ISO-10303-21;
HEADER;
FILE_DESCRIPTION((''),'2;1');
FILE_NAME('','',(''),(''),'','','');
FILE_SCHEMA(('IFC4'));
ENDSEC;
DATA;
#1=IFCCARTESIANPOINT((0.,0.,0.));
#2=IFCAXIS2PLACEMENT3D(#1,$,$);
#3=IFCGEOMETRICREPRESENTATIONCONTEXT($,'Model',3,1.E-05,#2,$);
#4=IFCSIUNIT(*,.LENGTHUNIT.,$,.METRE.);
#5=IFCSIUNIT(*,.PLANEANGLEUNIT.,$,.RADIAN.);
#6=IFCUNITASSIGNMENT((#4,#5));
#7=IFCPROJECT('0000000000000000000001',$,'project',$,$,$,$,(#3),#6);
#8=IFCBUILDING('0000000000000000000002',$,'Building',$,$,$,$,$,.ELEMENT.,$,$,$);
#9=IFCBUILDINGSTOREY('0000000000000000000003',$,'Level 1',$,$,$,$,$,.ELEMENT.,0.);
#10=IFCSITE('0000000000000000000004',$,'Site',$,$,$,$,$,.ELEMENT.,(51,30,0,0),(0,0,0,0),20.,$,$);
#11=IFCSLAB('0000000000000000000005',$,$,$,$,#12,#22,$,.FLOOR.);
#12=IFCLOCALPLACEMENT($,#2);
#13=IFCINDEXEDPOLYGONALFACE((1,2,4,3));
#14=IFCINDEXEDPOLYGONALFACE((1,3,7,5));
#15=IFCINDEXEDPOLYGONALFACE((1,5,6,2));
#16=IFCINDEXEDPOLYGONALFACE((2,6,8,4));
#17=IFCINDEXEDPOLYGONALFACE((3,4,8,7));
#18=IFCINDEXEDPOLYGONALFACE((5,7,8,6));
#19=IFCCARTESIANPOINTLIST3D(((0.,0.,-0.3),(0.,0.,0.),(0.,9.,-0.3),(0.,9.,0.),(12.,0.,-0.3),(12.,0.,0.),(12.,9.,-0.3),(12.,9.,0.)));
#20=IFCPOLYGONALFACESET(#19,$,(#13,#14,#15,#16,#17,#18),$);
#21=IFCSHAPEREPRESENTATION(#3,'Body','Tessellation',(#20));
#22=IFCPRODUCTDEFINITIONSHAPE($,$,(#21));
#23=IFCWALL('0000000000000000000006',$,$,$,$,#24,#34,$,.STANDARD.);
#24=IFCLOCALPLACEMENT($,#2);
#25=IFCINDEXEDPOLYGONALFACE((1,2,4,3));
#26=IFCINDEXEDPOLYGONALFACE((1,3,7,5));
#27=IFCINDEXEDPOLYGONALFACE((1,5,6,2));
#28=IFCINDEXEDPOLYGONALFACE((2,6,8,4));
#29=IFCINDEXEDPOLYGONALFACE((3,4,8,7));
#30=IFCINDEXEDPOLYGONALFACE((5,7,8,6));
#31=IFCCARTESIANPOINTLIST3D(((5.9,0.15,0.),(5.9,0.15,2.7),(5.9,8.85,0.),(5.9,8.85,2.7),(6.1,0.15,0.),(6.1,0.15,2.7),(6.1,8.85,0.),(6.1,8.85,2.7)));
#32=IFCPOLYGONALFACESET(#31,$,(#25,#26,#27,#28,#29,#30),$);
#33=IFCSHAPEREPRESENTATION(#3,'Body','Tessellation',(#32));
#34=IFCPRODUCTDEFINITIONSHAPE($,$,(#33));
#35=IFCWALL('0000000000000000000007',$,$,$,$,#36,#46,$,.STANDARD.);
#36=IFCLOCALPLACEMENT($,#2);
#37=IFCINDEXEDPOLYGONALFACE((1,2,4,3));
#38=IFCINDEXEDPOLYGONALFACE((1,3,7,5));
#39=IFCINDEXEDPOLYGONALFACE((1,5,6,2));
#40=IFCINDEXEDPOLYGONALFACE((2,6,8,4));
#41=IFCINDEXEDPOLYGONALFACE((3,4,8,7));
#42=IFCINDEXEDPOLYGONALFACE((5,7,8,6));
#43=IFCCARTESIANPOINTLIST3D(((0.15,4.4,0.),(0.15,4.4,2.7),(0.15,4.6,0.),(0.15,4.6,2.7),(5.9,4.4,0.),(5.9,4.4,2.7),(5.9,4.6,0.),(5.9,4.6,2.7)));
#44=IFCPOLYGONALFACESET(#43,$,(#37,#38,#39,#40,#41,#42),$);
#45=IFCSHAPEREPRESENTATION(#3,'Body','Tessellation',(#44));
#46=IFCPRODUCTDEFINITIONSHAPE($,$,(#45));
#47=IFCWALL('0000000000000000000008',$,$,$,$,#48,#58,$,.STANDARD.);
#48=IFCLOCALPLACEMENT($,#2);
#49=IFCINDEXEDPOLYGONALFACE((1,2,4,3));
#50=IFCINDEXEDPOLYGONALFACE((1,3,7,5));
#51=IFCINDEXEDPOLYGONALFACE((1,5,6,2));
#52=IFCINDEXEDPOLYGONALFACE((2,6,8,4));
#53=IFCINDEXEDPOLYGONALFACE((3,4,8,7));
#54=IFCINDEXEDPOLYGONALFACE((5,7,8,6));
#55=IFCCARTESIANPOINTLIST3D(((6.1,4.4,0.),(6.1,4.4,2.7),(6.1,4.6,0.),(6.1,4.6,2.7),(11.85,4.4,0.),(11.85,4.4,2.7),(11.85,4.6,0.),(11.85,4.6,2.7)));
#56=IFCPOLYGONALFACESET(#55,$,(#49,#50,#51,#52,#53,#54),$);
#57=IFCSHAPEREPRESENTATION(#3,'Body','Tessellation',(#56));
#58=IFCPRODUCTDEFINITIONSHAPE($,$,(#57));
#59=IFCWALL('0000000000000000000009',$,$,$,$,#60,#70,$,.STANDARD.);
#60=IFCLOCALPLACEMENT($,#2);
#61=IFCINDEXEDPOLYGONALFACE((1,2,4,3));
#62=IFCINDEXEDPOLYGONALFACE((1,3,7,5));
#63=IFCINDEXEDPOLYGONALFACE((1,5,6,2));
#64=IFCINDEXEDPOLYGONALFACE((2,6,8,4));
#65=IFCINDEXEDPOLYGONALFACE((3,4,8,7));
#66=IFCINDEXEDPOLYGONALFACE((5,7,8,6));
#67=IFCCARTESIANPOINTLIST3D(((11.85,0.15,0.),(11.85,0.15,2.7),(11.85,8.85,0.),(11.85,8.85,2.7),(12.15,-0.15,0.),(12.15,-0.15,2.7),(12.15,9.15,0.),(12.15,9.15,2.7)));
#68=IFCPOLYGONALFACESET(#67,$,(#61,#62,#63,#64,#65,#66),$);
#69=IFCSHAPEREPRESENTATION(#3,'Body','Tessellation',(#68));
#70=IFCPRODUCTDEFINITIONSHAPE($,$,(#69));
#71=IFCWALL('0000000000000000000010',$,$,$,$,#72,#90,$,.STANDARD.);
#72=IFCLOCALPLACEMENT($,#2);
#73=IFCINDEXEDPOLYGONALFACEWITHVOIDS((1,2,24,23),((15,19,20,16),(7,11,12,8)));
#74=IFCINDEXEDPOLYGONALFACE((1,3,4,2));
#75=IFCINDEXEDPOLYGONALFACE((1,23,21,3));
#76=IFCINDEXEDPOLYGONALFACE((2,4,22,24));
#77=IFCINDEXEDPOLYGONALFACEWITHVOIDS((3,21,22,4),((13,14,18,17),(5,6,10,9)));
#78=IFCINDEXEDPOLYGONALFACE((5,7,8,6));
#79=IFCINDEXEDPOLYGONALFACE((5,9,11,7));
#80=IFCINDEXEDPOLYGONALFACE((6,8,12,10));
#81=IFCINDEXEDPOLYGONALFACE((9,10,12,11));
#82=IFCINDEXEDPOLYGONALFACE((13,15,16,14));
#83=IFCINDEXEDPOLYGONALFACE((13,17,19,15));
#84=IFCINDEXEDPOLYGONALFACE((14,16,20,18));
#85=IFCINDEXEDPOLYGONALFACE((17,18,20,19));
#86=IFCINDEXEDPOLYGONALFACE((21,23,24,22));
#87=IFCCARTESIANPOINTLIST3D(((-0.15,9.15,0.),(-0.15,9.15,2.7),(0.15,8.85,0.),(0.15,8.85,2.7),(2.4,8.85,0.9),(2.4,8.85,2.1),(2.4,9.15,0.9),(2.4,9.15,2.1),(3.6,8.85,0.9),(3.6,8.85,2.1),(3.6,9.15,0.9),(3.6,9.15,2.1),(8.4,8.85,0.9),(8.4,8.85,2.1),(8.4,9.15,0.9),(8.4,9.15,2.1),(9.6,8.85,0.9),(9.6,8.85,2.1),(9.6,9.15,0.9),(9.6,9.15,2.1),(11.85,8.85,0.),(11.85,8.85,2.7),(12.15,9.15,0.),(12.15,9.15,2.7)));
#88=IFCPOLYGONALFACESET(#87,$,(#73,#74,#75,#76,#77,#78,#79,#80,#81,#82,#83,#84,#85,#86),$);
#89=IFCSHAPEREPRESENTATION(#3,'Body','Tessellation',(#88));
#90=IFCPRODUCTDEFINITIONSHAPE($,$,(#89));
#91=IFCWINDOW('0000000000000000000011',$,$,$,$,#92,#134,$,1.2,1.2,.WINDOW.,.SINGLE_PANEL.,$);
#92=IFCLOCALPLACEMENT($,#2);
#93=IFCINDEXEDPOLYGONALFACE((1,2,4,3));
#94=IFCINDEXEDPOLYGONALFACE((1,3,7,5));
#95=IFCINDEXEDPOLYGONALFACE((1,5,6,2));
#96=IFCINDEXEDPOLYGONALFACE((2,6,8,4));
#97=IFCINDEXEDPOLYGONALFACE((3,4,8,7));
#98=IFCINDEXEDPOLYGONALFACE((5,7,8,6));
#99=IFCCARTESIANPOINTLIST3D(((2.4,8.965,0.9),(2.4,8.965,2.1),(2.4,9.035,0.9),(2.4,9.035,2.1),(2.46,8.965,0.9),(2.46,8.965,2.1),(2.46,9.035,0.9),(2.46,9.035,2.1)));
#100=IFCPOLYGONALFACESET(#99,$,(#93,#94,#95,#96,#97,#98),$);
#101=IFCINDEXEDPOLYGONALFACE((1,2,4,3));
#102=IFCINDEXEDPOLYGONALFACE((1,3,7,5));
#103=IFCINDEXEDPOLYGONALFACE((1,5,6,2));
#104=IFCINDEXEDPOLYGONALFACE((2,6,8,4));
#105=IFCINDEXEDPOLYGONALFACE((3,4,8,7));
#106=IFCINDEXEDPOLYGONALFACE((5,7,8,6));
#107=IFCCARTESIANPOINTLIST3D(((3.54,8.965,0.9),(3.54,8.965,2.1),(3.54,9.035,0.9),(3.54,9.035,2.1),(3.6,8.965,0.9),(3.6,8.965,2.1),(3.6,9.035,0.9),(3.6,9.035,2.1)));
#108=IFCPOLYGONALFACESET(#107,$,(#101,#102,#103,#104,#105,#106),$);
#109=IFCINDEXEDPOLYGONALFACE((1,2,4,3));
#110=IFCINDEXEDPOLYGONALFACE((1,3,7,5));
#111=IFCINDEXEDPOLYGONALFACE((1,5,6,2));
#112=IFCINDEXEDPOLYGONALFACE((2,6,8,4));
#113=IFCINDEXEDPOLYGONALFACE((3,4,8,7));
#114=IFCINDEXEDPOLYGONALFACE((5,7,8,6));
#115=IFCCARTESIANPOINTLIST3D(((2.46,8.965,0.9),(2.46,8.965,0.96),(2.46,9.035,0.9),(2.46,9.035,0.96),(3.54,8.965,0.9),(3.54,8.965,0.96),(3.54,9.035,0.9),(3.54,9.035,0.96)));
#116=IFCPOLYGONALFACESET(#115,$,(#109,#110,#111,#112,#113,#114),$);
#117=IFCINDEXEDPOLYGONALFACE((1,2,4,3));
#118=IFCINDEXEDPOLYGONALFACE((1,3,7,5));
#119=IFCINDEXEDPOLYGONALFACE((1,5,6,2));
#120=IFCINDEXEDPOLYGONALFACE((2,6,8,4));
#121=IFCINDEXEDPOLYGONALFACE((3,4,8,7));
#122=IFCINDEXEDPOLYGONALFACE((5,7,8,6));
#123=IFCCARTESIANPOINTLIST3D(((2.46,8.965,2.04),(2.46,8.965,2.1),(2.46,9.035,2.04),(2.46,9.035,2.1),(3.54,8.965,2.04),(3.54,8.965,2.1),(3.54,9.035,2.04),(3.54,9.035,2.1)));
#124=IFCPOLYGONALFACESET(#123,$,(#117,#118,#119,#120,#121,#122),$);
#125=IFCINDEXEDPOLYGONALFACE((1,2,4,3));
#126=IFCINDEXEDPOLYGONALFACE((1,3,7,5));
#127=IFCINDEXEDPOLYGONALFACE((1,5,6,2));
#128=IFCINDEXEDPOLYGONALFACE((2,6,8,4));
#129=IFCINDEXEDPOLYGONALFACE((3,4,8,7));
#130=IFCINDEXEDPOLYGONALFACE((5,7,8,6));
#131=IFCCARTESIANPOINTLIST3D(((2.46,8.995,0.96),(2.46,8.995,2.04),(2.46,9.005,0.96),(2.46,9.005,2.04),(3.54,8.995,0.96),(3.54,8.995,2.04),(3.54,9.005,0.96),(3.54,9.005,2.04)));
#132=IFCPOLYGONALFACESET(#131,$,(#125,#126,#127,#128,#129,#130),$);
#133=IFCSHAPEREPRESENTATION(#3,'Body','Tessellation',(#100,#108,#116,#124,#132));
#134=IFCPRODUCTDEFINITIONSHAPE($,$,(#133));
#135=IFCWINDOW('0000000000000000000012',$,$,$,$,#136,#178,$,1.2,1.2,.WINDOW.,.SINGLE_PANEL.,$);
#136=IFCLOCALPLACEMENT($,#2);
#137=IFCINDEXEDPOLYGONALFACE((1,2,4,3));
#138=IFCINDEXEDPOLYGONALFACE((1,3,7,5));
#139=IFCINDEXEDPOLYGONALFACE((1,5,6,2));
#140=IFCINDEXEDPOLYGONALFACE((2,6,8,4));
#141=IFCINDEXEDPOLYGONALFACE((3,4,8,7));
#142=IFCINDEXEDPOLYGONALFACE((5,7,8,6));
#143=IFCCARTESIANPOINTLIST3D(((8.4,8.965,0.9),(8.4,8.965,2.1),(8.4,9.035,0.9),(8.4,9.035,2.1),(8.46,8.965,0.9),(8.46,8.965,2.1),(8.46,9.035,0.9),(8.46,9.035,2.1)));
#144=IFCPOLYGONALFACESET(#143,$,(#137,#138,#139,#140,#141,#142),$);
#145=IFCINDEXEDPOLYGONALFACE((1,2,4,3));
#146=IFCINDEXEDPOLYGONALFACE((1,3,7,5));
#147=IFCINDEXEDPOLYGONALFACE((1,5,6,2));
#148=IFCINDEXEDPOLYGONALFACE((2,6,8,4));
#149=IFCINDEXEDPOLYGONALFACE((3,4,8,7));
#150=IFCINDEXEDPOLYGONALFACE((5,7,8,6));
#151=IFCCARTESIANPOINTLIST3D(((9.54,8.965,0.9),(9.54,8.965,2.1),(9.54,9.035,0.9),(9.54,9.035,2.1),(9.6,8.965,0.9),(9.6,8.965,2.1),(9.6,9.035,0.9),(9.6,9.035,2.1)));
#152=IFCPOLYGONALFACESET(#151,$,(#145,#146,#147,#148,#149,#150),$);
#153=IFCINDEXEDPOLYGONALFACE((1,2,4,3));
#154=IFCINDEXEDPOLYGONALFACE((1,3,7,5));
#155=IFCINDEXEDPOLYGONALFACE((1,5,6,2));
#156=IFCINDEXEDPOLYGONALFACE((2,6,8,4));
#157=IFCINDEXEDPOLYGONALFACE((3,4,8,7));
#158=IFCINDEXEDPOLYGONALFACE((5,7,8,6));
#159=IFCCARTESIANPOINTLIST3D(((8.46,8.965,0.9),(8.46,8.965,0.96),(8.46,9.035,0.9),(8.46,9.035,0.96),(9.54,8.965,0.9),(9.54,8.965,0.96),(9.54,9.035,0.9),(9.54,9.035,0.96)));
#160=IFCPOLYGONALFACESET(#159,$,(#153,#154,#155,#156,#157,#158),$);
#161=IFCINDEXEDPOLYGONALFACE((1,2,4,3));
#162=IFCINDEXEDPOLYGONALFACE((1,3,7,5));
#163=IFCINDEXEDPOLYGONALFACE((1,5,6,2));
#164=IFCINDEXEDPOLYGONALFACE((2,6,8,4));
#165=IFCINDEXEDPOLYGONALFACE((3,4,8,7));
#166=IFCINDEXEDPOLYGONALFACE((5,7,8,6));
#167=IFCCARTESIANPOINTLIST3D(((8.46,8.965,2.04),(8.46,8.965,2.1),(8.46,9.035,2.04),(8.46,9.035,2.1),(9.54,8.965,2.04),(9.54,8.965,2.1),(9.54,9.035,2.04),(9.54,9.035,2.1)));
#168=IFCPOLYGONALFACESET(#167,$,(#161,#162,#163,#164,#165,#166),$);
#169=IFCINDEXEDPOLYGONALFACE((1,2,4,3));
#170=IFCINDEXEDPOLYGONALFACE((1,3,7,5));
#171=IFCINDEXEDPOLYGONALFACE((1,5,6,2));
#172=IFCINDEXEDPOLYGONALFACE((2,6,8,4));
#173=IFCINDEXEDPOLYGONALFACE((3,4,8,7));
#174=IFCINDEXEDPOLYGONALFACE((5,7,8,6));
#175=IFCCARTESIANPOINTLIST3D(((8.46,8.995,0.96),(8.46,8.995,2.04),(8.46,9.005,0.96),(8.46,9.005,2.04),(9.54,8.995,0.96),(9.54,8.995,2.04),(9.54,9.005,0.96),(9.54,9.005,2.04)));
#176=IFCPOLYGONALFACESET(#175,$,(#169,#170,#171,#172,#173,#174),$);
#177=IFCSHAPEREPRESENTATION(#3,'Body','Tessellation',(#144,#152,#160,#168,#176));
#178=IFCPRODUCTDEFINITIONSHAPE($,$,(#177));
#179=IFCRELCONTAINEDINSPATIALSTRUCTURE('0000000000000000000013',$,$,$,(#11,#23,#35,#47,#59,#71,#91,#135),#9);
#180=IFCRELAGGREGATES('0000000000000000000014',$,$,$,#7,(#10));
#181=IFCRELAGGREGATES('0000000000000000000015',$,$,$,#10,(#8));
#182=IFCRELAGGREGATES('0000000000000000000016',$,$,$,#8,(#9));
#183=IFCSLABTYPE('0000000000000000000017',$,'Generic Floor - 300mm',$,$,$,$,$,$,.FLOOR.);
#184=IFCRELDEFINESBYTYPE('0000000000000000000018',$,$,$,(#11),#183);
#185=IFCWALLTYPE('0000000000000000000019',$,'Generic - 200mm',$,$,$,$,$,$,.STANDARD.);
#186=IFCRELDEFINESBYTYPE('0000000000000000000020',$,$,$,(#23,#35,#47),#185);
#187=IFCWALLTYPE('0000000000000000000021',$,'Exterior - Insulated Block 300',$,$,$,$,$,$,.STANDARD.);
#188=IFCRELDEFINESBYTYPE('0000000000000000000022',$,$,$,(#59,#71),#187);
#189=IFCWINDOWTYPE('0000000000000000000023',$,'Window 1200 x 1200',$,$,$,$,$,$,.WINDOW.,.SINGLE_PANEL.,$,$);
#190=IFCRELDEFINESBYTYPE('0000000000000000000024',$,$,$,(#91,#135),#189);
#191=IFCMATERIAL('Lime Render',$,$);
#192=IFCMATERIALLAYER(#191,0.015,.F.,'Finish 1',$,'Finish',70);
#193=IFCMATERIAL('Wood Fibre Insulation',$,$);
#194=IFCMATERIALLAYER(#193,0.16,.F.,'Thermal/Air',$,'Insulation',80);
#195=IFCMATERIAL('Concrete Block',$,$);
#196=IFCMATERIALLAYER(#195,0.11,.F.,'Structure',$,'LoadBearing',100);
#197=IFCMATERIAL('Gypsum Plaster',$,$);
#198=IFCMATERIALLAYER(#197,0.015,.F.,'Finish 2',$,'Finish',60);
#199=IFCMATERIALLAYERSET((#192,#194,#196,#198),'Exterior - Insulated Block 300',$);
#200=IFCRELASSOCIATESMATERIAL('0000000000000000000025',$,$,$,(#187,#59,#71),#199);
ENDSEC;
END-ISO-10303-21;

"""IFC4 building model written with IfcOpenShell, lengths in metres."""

from ifc_helpers import new_model, si_unit, frame, frame_2d, origin, origin_with_axes, origin_2d, place, context, project, spatial, polyline, rectangle, outline, extrude, material, layer, layer_set, layer_usage, type_object, element, fill, save


model = new_model("IFC4")

# Units and contexts
model_context = context("Model", 3, precision=1e-05, world=origin())
ifc_project = project(units=[si_unit("LENGTHUNIT", "METRE"), si_unit("PLANEANGLEUNIT", "RADIAN")], contexts=[model_context])

# Site, building, storey
site = spatial("IfcSite", under=ifc_project, Name="Site", CompositionType="ELEMENT", RefLatitude=(51, 30, 0, 0), RefLongitude=(0, 0, 0, 0), RefElevation=20.0)
building = spatial("IfcBuilding", under=site, Name="Building", CompositionType="ELEMENT")
storey = spatial("IfcBuildingStorey", under=building, Name="Level 1", CompositionType="ELEMENT", Elevation=0.0)

# Slab
slab_type = type_object("IfcSlabType", Name="Generic Floor - 300mm", PredefinedType="FLOOR")
slab_placement = place(None, origin())
element("IfcSlab", 1, at=slab_placement, inside=storey, type_object=slab_type, PredefinedType="FLOOR", context=model_context, shape_type="SweptSolid", body=[
    extrude(outline(polyline([(0.0, 0.0), (12.0, 0.0), (12.0, 9.0), (0.0, 9.0), (0.0, 0.0)])), origin(), (0.0, 0.0, -1.0), 0.3),
])

# Walls
wall_type_1 = type_object("IfcWallType", Name="Generic - 200mm", PredefinedType="STANDARD")
wall_1_placement = place(None, frame((6.0, 0.0, 0.0), z_axis=(0.0, 0.0, 1.0), x_axis=(0.0, 1.0, 0.0)))
element("IfcWall", 2, at=wall_1_placement, inside=storey, type_object=wall_type_1, PredefinedType="STANDARD", context=model_context, shape_type="SweptSolid", body=[
    extrude(outline(polyline([(0.15, -0.1), (8.85, -0.1), (8.85, 0.1), (0.15, 0.1), (0.15, -0.1)])), origin(), (0.0, 0.0, 1.0), 2.7),
])
wall_2_placement = place(None, frame((0.0, 4.5, 0.0), z_axis=(0.0, 0.0, 1.0), x_axis=(1.0, 0.0, 0.0)))
element("IfcWall", 3, at=wall_2_placement, inside=storey, type_object=wall_type_1, PredefinedType="STANDARD", context=model_context, shape_type="SweptSolid", body=[
    extrude(outline(polyline([(0.15, -0.1), (5.9, -0.1), (5.9, 0.1), (0.15, 0.1), (0.15, -0.1)])), origin(), (0.0, 0.0, 1.0), 2.7),
])
wall_3_placement = place(None, frame((6.0, 4.5, 0.0), z_axis=(0.0, 0.0, 1.0), x_axis=(1.0, 0.0, 0.0)))
element("IfcWall", 4, at=wall_3_placement, inside=storey, type_object=wall_type_1, PredefinedType="STANDARD", context=model_context, shape_type="SweptSolid", body=[
    extrude(outline(polyline([(0.1, -0.1), (5.85, -0.1), (5.85, 0.1), (0.1, 0.1), (0.1, -0.1)])), origin(), (0.0, 0.0, 1.0), 2.7),
])

# Shared definitions
ifc_material_1 = material(Name="Lime Render")
ifc_layer_1 = layer(ifc_material_1, 0.015, ventilated=False, Name="Finish 1", Category="Finish", Priority=70)
ifc_material_2 = material(Name="Wood Fibre Insulation")
ifc_layer_2 = layer(ifc_material_2, 0.16, ventilated=False, Name="Thermal/Air", Category="Insulation", Priority=80)
ifc_material_3 = material(Name="Concrete Block")
ifc_layer_3 = layer(ifc_material_3, 0.11, ventilated=False, Name="Structure", Category="LoadBearing", Priority=100)
ifc_material_4 = material(Name="Gypsum Plaster")
ifc_layer_4 = layer(ifc_material_4, 0.015, ventilated=False, Name="Finish 2", Category="Finish", Priority=60)
ifc_layer_set = layer_set([ifc_layer_1, ifc_layer_2, ifc_layer_3, ifc_layer_4], Name="Exterior - Insulated Block 300")
ifc_layer_usage = layer_usage(ifc_layer_set, "AXIS2", "POSITIVE", -0.15)
wall_type_2 = type_object("IfcWallType", Name="Exterior - Insulated Block 300", PredefinedType="STANDARD", material=ifc_layer_set)

# Wall
wall_4_placement = place(None, frame((12.0, 9.0, 0.0), z_axis=(0.0, 0.0, 1.0), x_axis=(0.0, -1.0, 0.0)))
element("IfcWall", 5, at=wall_4_placement, inside=storey, type_object=wall_type_2, material=ifc_layer_usage, PredefinedType="STANDARD", context=model_context, shape_type="SweptSolid", body=[
    extrude(outline(polyline([(0.15, -0.15), (8.85, -0.15), (9.15, 0.15), (-0.15, 0.15), (0.15, -0.15)])), origin(), (0.0, 0.0, 1.0), 2.7),
])

# Wall, openings, windows
wall_5_placement = place(None, frame((0.0, 9.0, 0.0), z_axis=(0.0, 0.0, 1.0), x_axis=(1.0, 0.0, 0.0)))
wall_5 = element("IfcWall", 6, at=wall_5_placement, inside=storey, type_object=wall_type_2, material=ifc_layer_usage, PredefinedType="STANDARD", context=model_context, shape_type="SweptSolid", body=[
    extrude(outline(polyline([(0.15, -0.15), (11.85, -0.15), (12.15, 0.15), (-0.15, 0.15), (0.15, -0.15)])), origin(), (0.0, 0.0, 1.0), 2.7),
])
opening_1_placement = place(wall_5_placement, frame((3.0, 0.0, 0.9), z_axis=(0.0, 0.0, 1.0), x_axis=(1.0, 0.0, 0.0)))
opening_1 = element("IfcOpeningElement", 7, at=opening_1_placement, cuts=wall_5, PredefinedType="OPENING", context=model_context, shape_type="SweptSolid", body=[
    extrude(rectangle(XDim=1.2, YDim=0.302, at=origin_2d()), origin(), (0.0, 0.0, 1.0), 1.2),
])
opening_2_placement = place(wall_5_placement, frame((9.0, 0.0, 0.9), z_axis=(0.0, 0.0, 1.0), x_axis=(1.0, 0.0, 0.0)))
opening_2 = element("IfcOpeningElement", 8, at=opening_2_placement, cuts=wall_5, PredefinedType="OPENING", context=model_context, shape_type="SweptSolid", body=[
    extrude(rectangle(XDim=1.2, YDim=0.302, at=origin_2d()), origin(), (0.0, 0.0, 1.0), 1.2),
])
window_type_1 = type_object("IfcWindowType", Name="Window 1200 x 1200", PartitioningType="SINGLE_PANEL", PredefinedType="WINDOW")
window_1_placement = place(opening_1_placement, origin_with_axes())
window_1 = element("IfcWindow", 9, at=window_1_placement, inside=storey, type_object=window_type_1, OverallHeight=1.2, OverallWidth=1.2, PartitioningType="SINGLE_PANEL", PredefinedType="WINDOW", context=model_context, shape_type="SweptSolid", body=[
    extrude(rectangle(XDim=0.06, YDim=0.07, at=frame_2d((-0.57, 0.0))), origin(), (0.0, 0.0, 1.0), 1.2),
    extrude(rectangle(XDim=0.06, YDim=0.07, at=frame_2d((0.57, 0.0))), origin(), (0.0, 0.0, 1.0), 1.2),
    extrude(rectangle(XDim=1.08, YDim=0.07, at=origin_2d()), origin(), (0.0, 0.0, 1.0), 0.06),
    extrude(rectangle(XDim=1.08, YDim=0.07, at=origin_2d()), frame((0.0, 0.0, 1.14)), (0.0, 0.0, 1.0), 0.06),
    extrude(rectangle(XDim=1.08, YDim=0.01, at=origin_2d()), frame((0.0, 0.0, 0.06)), (0.0, 0.0, 1.0), 1.08),
])
fill(opening_1, window_1)
window_2_placement = place(opening_2_placement, origin_with_axes())
window_2 = element("IfcWindow", 10, at=window_2_placement, inside=storey, type_object=window_type_1, OverallHeight=1.2, OverallWidth=1.2, PartitioningType="SINGLE_PANEL", PredefinedType="WINDOW", context=model_context, shape_type="SweptSolid", body=[
    extrude(rectangle(XDim=0.06, YDim=0.07, at=frame_2d((-0.57, 0.0))), origin(), (0.0, 0.0, 1.0), 1.2),
    extrude(rectangle(XDim=0.06, YDim=0.07, at=frame_2d((0.57, 0.0))), origin(), (0.0, 0.0, 1.0), 1.2),
    extrude(rectangle(XDim=1.08, YDim=0.07, at=origin_2d()), origin(), (0.0, 0.0, 1.0), 0.06),
    extrude(rectangle(XDim=1.08, YDim=0.07, at=origin_2d()), frame((0.0, 0.0, 1.14)), (0.0, 0.0, 1.0), 0.06),
    extrude(rectangle(XDim=1.08, YDim=0.01, at=origin_2d()), frame((0.0, 0.0, 0.06)), (0.0, 0.0, 1.0), 1.08),
])
fill(opening_2, window_2)

save(model, "model.ifc")
